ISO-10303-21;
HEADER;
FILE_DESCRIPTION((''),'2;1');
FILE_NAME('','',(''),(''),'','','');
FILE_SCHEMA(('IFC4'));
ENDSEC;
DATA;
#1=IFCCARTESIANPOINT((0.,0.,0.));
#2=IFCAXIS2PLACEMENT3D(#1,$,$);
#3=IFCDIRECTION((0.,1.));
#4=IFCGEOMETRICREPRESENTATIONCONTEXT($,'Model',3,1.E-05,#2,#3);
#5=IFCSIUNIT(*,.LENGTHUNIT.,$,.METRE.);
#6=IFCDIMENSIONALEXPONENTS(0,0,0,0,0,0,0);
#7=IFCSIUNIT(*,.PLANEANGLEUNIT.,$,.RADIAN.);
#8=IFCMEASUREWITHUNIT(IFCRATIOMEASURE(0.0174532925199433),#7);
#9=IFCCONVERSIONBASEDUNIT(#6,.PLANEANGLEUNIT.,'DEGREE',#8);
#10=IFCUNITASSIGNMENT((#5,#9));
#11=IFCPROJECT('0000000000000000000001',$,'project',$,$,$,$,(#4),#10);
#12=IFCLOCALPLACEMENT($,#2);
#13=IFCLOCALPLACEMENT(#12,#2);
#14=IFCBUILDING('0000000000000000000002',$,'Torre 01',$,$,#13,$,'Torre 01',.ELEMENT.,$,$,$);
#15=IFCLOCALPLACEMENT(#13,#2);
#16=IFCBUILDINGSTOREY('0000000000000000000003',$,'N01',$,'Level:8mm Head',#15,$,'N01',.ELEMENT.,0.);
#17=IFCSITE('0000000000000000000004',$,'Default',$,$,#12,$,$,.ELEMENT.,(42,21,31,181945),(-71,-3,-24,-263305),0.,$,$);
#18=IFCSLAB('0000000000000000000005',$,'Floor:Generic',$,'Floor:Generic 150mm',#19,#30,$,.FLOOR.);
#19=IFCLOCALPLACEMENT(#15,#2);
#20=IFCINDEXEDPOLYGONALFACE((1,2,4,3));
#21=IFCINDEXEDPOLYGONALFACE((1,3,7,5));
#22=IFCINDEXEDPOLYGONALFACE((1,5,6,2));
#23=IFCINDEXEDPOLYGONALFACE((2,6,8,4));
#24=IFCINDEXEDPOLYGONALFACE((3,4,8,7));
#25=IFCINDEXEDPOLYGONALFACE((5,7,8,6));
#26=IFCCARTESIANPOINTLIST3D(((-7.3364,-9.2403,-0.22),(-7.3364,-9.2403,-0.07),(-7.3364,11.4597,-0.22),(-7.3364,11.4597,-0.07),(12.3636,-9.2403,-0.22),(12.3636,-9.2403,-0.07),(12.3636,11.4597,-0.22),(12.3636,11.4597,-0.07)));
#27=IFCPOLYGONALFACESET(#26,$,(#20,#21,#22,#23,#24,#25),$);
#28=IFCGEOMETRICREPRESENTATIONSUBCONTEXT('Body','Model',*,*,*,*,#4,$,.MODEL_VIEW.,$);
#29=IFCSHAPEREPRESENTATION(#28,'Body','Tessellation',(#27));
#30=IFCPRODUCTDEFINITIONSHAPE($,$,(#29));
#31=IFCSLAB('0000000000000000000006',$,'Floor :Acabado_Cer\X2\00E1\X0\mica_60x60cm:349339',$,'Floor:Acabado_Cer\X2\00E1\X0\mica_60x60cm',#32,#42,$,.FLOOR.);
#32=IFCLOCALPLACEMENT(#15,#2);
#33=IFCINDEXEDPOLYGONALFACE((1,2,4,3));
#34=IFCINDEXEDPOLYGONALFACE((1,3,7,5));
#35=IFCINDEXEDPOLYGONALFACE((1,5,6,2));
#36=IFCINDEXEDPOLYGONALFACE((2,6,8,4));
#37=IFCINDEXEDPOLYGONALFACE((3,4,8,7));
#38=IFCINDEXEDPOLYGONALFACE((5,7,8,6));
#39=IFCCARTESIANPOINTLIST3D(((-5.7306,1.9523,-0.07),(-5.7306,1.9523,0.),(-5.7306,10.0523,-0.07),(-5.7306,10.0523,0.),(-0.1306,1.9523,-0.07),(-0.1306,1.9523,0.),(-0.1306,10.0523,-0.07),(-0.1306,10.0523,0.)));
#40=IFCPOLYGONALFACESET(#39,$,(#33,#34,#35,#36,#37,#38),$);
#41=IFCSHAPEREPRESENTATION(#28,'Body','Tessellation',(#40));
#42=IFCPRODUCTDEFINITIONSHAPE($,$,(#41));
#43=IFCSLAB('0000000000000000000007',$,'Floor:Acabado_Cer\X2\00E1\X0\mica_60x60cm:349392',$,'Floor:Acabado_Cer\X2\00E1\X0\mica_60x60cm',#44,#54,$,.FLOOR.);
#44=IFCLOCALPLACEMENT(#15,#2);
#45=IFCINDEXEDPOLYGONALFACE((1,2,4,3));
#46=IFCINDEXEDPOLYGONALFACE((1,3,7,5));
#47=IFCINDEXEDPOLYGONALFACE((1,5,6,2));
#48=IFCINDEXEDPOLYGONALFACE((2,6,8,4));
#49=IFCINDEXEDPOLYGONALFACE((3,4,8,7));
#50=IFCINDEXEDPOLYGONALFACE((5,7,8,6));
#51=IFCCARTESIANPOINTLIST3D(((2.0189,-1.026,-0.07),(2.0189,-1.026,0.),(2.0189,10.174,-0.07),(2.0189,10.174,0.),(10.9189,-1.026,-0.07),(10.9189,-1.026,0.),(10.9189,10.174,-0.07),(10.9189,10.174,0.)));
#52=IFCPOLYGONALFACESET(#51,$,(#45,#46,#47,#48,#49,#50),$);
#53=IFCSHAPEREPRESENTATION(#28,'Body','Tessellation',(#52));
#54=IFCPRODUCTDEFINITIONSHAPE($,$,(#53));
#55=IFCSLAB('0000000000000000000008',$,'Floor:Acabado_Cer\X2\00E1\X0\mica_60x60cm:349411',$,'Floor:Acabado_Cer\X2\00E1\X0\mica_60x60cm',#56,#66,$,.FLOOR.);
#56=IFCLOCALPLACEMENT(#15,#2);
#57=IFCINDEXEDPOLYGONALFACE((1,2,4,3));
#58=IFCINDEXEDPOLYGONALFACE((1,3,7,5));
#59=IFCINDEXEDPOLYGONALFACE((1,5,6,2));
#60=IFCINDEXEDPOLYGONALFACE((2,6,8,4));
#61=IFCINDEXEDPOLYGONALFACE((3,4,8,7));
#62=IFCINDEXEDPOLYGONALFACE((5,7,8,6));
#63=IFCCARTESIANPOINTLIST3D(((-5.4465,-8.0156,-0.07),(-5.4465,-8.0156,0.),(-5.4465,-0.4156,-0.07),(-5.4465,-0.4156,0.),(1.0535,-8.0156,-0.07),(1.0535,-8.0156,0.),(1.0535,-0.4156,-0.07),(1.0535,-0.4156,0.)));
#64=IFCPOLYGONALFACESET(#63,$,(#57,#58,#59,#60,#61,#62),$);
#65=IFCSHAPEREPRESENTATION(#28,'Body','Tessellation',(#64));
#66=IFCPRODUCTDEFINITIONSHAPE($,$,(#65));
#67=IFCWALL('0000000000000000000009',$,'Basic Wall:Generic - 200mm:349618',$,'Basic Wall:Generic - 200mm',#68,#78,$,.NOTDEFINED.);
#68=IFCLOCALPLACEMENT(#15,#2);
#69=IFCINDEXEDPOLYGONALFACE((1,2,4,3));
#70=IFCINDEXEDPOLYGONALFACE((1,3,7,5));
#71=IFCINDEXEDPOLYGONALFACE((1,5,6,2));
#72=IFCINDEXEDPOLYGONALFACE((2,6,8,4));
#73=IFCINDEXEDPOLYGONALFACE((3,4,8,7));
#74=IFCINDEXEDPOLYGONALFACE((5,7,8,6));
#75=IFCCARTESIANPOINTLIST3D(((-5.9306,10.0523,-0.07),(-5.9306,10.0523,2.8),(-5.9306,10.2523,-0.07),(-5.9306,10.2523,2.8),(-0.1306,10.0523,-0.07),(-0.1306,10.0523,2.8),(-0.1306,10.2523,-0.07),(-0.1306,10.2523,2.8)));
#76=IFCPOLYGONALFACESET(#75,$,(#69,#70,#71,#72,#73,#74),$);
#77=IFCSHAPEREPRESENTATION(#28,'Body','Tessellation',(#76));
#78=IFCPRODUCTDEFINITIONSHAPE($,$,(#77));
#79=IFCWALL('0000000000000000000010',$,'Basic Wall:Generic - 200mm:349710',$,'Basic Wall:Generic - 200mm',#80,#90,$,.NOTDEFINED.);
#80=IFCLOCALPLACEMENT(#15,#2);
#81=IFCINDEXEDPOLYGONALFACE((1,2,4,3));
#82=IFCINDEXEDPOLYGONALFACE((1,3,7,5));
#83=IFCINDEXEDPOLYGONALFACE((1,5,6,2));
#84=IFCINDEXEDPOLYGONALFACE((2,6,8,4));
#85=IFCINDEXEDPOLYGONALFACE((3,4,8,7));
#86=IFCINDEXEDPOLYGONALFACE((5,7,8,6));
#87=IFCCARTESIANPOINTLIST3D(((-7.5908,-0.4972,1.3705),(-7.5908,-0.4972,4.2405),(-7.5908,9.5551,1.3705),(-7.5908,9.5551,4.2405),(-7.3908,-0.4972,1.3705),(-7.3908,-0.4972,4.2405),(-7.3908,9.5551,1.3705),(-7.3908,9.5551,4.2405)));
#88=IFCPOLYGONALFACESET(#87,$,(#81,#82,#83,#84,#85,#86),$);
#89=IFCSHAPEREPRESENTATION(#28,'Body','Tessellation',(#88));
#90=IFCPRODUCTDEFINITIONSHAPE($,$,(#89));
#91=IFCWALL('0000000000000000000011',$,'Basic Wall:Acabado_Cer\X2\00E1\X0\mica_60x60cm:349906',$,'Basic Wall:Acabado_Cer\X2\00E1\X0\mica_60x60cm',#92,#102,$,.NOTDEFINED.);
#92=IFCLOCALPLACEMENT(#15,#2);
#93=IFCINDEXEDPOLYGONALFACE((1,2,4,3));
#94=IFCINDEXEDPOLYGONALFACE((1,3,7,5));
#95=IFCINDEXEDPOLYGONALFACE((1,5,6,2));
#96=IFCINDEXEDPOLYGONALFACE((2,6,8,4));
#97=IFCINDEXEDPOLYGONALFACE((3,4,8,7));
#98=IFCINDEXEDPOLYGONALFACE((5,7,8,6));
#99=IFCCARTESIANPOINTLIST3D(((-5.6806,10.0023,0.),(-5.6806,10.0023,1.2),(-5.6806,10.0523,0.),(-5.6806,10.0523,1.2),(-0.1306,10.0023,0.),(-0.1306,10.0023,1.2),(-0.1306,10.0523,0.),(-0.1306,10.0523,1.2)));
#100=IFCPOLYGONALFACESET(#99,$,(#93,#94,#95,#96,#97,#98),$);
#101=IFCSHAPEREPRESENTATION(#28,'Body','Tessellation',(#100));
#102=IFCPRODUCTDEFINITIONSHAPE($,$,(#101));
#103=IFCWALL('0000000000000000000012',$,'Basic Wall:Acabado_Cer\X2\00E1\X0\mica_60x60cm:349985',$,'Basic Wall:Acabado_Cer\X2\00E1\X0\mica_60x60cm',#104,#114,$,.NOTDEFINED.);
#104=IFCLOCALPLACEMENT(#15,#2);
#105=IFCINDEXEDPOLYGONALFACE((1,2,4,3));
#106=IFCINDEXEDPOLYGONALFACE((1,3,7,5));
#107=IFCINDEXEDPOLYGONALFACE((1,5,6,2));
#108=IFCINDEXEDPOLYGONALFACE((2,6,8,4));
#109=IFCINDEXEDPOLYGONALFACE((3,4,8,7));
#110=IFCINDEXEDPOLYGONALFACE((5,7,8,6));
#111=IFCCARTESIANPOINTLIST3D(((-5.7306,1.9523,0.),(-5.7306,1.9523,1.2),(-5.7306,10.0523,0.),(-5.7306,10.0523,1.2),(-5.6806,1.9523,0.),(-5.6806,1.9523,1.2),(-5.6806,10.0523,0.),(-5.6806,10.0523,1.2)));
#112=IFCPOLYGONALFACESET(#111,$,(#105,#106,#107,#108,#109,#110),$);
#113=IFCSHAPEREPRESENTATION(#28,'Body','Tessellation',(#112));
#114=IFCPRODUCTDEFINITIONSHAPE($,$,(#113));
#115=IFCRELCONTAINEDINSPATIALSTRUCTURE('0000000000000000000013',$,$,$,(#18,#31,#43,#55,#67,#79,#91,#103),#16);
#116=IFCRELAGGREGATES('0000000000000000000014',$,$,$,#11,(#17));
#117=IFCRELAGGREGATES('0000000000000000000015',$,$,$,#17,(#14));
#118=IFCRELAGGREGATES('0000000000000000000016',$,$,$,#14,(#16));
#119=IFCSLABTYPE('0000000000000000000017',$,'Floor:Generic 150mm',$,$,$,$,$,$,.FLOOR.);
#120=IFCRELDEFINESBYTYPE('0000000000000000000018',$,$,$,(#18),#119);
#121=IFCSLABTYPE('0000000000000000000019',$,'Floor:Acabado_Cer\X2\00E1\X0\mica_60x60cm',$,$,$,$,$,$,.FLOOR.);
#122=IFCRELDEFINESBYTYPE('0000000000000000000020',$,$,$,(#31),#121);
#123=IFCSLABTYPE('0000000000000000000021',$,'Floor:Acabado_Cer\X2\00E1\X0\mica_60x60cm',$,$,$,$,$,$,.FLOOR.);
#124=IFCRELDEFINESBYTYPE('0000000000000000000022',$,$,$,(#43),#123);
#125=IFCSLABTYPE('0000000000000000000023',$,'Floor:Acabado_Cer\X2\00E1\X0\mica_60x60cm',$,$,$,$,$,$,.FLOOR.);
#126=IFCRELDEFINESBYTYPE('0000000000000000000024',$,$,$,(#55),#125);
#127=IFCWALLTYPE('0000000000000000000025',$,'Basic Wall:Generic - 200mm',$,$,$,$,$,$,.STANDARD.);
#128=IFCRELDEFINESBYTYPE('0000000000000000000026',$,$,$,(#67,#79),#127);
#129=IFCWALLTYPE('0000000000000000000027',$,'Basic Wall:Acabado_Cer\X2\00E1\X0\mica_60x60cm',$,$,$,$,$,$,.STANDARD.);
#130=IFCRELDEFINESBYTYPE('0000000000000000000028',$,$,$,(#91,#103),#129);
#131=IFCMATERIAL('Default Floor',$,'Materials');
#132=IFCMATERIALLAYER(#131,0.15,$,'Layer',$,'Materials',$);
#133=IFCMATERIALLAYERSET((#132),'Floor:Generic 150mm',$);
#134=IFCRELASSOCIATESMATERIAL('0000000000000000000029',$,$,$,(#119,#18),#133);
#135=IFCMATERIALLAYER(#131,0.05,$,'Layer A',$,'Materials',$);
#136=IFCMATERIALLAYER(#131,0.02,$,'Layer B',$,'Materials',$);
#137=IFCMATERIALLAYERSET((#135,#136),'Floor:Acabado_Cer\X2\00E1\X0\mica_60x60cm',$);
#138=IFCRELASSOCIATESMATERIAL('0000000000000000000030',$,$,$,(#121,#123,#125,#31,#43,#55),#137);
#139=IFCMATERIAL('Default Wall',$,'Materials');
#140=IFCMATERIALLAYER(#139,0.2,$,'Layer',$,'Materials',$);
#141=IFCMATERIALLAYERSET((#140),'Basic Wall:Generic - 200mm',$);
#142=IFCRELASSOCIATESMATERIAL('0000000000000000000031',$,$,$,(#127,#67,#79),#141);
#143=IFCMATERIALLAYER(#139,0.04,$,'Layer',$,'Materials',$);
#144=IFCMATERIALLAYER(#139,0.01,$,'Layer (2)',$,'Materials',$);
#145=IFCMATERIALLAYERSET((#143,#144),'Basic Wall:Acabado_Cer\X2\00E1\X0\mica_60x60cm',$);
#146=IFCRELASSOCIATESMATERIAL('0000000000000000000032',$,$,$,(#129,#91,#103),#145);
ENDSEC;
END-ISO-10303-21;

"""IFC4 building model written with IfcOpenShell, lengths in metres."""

from ifc_helpers import new_model, entity, si_unit, converted_unit, direction, frame, frame_2d, origin, origin_2d_with_axis, place, context, subcontext, project, spatial, polyline, indexed_curve, rectangle, outline, extrude, clip, bounded_halfspace, material, layer, layer_set, layer_usage, type_object, element, save


model = new_model("IFC4")

# Units and contexts
model_context = context("Model", 3, precision=1e-05, world=origin(), true_north=direction((0.0, 1.0)))
body_context = subcontext(model_context, "Body", "Model", "MODEL_VIEW")
ifc_project = project(units=[si_unit("LENGTHUNIT", "METRE"), converted_unit("PLANEANGLEUNIT", "DEGREE", entity("IfcRatioMeasure", 0.0174532925199433), si_unit("PLANEANGLEUNIT", "RADIAN"), dimensions=[0, 0, 0, 0, 0, 0, 0])], contexts=[model_context])

# Site, building, storey
site_placement = place(None, origin())
site = spatial("IfcSite", under=ifc_project, at=site_placement, Name="Default", CompositionType="ELEMENT", RefLatitude=(42, 21, 31, 181945), RefLongitude=(-71, -3, -24, -263305), RefElevation=0.0)
building_placement = place(site_placement, origin())
building = spatial("IfcBuilding", under=site, at=building_placement, Name="Torre 01", LongName="Torre 01", CompositionType="ELEMENT")
storey_placement = place(building_placement, origin())
storey = spatial("IfcBuildingStorey", under=building, at=storey_placement, Name="N01", ObjectType="Level:8mm Head", LongName="N01", CompositionType="ELEMENT", Elevation=0.0)

# Slabs
ifc_material_1 = material(Name="Default Floor", Category="Materials")
ifc_layer_1 = layer(ifc_material_1, 0.15, Name="Layer", Category="Materials")
ifc_layer_set_1 = layer_set([ifc_layer_1], Name="Floor:Generic 150mm")
ifc_layer_usage_1 = layer_usage(ifc_layer_set_1, "AXIS3", "POSITIVE", 0.0)
slab_type_1 = type_object("IfcSlabType", Name="Floor:Generic 150mm", PredefinedType="FLOOR", material=ifc_layer_set_1)
slab_1_placement = place(storey_placement, origin())
element("IfcSlab", 1, at=slab_1_placement, inside=storey, type_object=slab_type_1, material=ifc_layer_usage_1, Name="Floor:Generic", ObjectType="Floor:Generic 150mm", PredefinedType="FLOOR", context=body_context, shape_type="SweptSolid", body=[
    extrude(rectangle(XDim=20.7, YDim=19.7, at=origin_2d_with_axis()), frame((2.5136, 1.1097, -0.07), z_axis=(0.0, 0.0, -1.0), x_axis=(0.0, 1.0, 0.0)), (0.0, 0.0, 1.0), 0.15),
])
ifc_layer_2 = layer(ifc_material_1, 0.05, Name="Layer A", Category="Materials")
ifc_layer_3 = layer(ifc_material_1, 0.02, Name="Layer B", Category="Materials")
ifc_layer_set_2 = layer_set([ifc_layer_2, ifc_layer_3], Name="Floor:Acabado_Cerámica_60x60cm")
ifc_layer_usage_2 = layer_usage(ifc_layer_set_2, "AXIS3", "POSITIVE", 0.0)
slab_type_2 = type_object("IfcSlabType", Name="Floor:Acabado_Cerámica_60x60cm", PredefinedType="FLOOR", material=ifc_layer_set_2)
slab_2_placement = place(storey_placement, origin())
element("IfcSlab", 2, at=slab_2_placement, inside=storey, type_object=slab_type_2, material=ifc_layer_usage_2, Name="Floor :Acabado_Cerámica_60x60cm:349339", ObjectType="Floor:Acabado_Cerámica_60x60cm", PredefinedType="FLOOR", context=body_context, shape_type="SweptSolid", body=[
    extrude(rectangle(XDim=8.1, YDim=5.6, at=frame_2d((0.0, 0.0), x_axis=(1.0, 0.0))), frame((-2.9306, 6.0023, 0.0), z_axis=(0.0, 0.0, -1.0), x_axis=(0.0, 1.0, 0.0)), (0.0, 0.0, 1.0), 0.07),
])
ifc_layer_usage_3 = layer_usage(ifc_layer_set_2, "AXIS3", "POSITIVE", 0.0)
slab_type_3 = type_object("IfcSlabType", Name="Floor:Acabado_Cerámica_60x60cm", PredefinedType="FLOOR", material=ifc_layer_set_2)
slab_3_placement = place(storey_placement, origin())
element("IfcSlab", 3, at=slab_3_placement, inside=storey, type_object=slab_type_3, material=ifc_layer_usage_3, Name="Floor:Acabado_Cerámica_60x60cm:349392", ObjectType="Floor:Acabado_Cerámica_60x60cm", PredefinedType="FLOOR", context=body_context, shape_type="SweptSolid", body=[
    extrude(rectangle(XDim=11.2, YDim=8.9, at=origin_2d_with_axis()), frame((6.4689, 4.574, 0.0), z_axis=(0.0, 0.0, -1.0), x_axis=(0.0, 1.0, 0.0)), (0.0, 0.0, 1.0), 0.07),
])
ifc_layer_usage_4 = layer_usage(ifc_layer_set_2, "AXIS3", "POSITIVE", 0.0)
slab_type_4 = type_object("IfcSlabType", Name="Floor:Acabado_Cerámica_60x60cm", PredefinedType="FLOOR", material=ifc_layer_set_2)
slab_4_placement = place(storey_placement, origin())
element("IfcSlab", 4, at=slab_4_placement, inside=storey, type_object=slab_type_4, material=ifc_layer_usage_4, Name="Floor:Acabado_Cerámica_60x60cm:349411", ObjectType="Floor:Acabado_Cerámica_60x60cm", PredefinedType="FLOOR", context=body_context, shape_type="SweptSolid", body=[
    extrude(rectangle(XDim=7.6, YDim=6.5, at=frame_2d((0.0, 0.0), x_axis=(1.0, 0.0))), frame((-2.1965, -4.2156, 0.0), z_axis=(0.0, 0.0, -1.0), x_axis=(0.0, 1.0, 0.0)), (0.0, 0.0, 1.0), 0.07),
])

# Walls
ifc_material_2 = material(Name="Default Wall", Category="Materials")
ifc_layer_4 = layer(ifc_material_2, 0.2, Name="Layer", Category="Materials")
ifc_layer_set_3 = layer_set([ifc_layer_4], Name="Basic Wall:Generic - 200mm")
ifc_layer_usage_5 = layer_usage(ifc_layer_set_3, "AXIS2", "POSITIVE", -0.1)
wall_type_1 = type_object("IfcWallType", Name="Basic Wall:Generic - 200mm", PredefinedType="STANDARD", material=ifc_layer_set_3)
wall_1_placement = place(storey_placement, frame((-0.1306, 10.1523, -0.07), z_axis=(0.0, 0.0, 1.0), x_axis=(-1.0, 0.0, 0.0)))
element("IfcWall", 5, at=wall_1_placement, inside=storey, type_object=wall_type_1, material=ifc_layer_usage_5, Name="Basic Wall:Generic - 200mm:349618", ObjectType="Basic Wall:Generic - 200mm", PredefinedType="NOTDEFINED", context=body_context, shape_type="SweptSolid", body=[
    extrude(rectangle(XDim=5.8, YDim=0.2, at=frame_2d((2.9, 0.0), x_axis=(-1.0, 0.0))), origin(), (0.0, 0.0, 1.0), 2.87),
])
ifc_layer_usage_6 = layer_usage(ifc_layer_set_3, "AXIS2", "POSITIVE", -0.1)
wall_2_placement = place(storey_placement, frame((-7.4908, 9.5551, 1.3705), z_axis=(0.0, 0.0, 1.0), x_axis=(0.0, -1.0, 0.0)))
element("IfcWall", 6, at=wall_2_placement, inside=storey, type_object=wall_type_1, material=ifc_layer_usage_6, Name="Basic Wall:Generic - 200mm:349710", ObjectType="Basic Wall:Generic - 200mm", PredefinedType="NOTDEFINED", context=body_context, shape_type="SweptSolid", body=[
    extrude(outline(indexed_curve([(0.0, 0.0), (0.0, 0.2), (10.0523, 0.2), (10.0523, 0.0), (0.0, 0.0)], self_intersect=False)), frame((0.0, -0.1, 0.0), z_axis=(0.0, 0.0, 1.0), x_axis=(1.0, 0.0, 0.0)), (0.0, 0.0, 1.0), 2.87),
])
ifc_layer_5 = layer(ifc_material_2, 0.04, Name="Layer", Category="Materials")
ifc_layer_6 = layer(ifc_material_2, 0.01, Name="Layer (2)", Category="Materials")
ifc_layer_set_4 = layer_set([ifc_layer_5, ifc_layer_6], Name="Basic Wall:Acabado_Cerámica_60x60cm")
ifc_layer_usage_7 = layer_usage(ifc_layer_set_4, "AXIS2", "NEGATIVE", 0.025)
wall_type_2 = type_object("IfcWallType", Name="Basic Wall:Acabado_Cerámica_60x60cm", PredefinedType="STANDARD", material=ifc_layer_set_4)
wall_3_placement = place(storey_placement, frame((-0.1306, 10.0273, 0.0), z_axis=(0.0, 0.0, 1.0), x_axis=(-1.0, 0.0, 0.0)))
element("IfcWall", 7, at=wall_3_placement, inside=storey, type_object=wall_type_2, material=ifc_layer_usage_7, Name="Basic Wall:Acabado_Cerámica_60x60cm:349906", ObjectType="Basic Wall:Acabado_Cerámica_60x60cm", PredefinedType="NOTDEFINED", context=body_context, shape_type="Clipping", body=[
    clip(extrude(rectangle(XDim=5.55, YDim=0.05, at=frame_2d((2.775, 0.0), x_axis=(-1.0, 0.0))), origin(), (0.0, 0.0, 1.0), 1.2), bounded_halfspace(frame((5.55, -0.025, 1.2), z_axis=(-1.0, 0.0, 0.0), x_axis=(0.0, -1.0, 0.0)), True, frame((5.55, -0.025, 1.2), z_axis=(-1.0, 0.0, 0.0), x_axis=(0.0, -1.0, 0.0)), polyline([(0.0, 0.0), (-0.05, 0.0), (-0.05, -1.2), (0.0, -1.2), (0.0, 0.0)]))),
])
ifc_layer_usage_8 = layer_usage(ifc_layer_set_4, "AXIS2", "NEGATIVE", 0.025)
wall_4_placement = place(storey_placement, frame((-5.7056, 10.0523, 0.0), z_axis=(0.0, 0.0, 1.0), x_axis=(0.0, -1.0, 0.0)))
element("IfcWall", 8, at=wall_4_placement, inside=storey, type_object=wall_type_2, material=ifc_layer_usage_8, Name="Basic Wall:Acabado_Cerámica_60x60cm:349985", ObjectType="Basic Wall:Acabado_Cerámica_60x60cm", PredefinedType="NOTDEFINED", context=body_context, shape_type="SweptSolid", body=[
    extrude(rectangle(XDim=8.1, YDim=0.05, at=frame_2d((4.05, 0.0), x_axis=(-1.0, 0.0))), origin(), (0.0, 0.0, 1.0), 1.2),
])

save(model, "model.ifc")
